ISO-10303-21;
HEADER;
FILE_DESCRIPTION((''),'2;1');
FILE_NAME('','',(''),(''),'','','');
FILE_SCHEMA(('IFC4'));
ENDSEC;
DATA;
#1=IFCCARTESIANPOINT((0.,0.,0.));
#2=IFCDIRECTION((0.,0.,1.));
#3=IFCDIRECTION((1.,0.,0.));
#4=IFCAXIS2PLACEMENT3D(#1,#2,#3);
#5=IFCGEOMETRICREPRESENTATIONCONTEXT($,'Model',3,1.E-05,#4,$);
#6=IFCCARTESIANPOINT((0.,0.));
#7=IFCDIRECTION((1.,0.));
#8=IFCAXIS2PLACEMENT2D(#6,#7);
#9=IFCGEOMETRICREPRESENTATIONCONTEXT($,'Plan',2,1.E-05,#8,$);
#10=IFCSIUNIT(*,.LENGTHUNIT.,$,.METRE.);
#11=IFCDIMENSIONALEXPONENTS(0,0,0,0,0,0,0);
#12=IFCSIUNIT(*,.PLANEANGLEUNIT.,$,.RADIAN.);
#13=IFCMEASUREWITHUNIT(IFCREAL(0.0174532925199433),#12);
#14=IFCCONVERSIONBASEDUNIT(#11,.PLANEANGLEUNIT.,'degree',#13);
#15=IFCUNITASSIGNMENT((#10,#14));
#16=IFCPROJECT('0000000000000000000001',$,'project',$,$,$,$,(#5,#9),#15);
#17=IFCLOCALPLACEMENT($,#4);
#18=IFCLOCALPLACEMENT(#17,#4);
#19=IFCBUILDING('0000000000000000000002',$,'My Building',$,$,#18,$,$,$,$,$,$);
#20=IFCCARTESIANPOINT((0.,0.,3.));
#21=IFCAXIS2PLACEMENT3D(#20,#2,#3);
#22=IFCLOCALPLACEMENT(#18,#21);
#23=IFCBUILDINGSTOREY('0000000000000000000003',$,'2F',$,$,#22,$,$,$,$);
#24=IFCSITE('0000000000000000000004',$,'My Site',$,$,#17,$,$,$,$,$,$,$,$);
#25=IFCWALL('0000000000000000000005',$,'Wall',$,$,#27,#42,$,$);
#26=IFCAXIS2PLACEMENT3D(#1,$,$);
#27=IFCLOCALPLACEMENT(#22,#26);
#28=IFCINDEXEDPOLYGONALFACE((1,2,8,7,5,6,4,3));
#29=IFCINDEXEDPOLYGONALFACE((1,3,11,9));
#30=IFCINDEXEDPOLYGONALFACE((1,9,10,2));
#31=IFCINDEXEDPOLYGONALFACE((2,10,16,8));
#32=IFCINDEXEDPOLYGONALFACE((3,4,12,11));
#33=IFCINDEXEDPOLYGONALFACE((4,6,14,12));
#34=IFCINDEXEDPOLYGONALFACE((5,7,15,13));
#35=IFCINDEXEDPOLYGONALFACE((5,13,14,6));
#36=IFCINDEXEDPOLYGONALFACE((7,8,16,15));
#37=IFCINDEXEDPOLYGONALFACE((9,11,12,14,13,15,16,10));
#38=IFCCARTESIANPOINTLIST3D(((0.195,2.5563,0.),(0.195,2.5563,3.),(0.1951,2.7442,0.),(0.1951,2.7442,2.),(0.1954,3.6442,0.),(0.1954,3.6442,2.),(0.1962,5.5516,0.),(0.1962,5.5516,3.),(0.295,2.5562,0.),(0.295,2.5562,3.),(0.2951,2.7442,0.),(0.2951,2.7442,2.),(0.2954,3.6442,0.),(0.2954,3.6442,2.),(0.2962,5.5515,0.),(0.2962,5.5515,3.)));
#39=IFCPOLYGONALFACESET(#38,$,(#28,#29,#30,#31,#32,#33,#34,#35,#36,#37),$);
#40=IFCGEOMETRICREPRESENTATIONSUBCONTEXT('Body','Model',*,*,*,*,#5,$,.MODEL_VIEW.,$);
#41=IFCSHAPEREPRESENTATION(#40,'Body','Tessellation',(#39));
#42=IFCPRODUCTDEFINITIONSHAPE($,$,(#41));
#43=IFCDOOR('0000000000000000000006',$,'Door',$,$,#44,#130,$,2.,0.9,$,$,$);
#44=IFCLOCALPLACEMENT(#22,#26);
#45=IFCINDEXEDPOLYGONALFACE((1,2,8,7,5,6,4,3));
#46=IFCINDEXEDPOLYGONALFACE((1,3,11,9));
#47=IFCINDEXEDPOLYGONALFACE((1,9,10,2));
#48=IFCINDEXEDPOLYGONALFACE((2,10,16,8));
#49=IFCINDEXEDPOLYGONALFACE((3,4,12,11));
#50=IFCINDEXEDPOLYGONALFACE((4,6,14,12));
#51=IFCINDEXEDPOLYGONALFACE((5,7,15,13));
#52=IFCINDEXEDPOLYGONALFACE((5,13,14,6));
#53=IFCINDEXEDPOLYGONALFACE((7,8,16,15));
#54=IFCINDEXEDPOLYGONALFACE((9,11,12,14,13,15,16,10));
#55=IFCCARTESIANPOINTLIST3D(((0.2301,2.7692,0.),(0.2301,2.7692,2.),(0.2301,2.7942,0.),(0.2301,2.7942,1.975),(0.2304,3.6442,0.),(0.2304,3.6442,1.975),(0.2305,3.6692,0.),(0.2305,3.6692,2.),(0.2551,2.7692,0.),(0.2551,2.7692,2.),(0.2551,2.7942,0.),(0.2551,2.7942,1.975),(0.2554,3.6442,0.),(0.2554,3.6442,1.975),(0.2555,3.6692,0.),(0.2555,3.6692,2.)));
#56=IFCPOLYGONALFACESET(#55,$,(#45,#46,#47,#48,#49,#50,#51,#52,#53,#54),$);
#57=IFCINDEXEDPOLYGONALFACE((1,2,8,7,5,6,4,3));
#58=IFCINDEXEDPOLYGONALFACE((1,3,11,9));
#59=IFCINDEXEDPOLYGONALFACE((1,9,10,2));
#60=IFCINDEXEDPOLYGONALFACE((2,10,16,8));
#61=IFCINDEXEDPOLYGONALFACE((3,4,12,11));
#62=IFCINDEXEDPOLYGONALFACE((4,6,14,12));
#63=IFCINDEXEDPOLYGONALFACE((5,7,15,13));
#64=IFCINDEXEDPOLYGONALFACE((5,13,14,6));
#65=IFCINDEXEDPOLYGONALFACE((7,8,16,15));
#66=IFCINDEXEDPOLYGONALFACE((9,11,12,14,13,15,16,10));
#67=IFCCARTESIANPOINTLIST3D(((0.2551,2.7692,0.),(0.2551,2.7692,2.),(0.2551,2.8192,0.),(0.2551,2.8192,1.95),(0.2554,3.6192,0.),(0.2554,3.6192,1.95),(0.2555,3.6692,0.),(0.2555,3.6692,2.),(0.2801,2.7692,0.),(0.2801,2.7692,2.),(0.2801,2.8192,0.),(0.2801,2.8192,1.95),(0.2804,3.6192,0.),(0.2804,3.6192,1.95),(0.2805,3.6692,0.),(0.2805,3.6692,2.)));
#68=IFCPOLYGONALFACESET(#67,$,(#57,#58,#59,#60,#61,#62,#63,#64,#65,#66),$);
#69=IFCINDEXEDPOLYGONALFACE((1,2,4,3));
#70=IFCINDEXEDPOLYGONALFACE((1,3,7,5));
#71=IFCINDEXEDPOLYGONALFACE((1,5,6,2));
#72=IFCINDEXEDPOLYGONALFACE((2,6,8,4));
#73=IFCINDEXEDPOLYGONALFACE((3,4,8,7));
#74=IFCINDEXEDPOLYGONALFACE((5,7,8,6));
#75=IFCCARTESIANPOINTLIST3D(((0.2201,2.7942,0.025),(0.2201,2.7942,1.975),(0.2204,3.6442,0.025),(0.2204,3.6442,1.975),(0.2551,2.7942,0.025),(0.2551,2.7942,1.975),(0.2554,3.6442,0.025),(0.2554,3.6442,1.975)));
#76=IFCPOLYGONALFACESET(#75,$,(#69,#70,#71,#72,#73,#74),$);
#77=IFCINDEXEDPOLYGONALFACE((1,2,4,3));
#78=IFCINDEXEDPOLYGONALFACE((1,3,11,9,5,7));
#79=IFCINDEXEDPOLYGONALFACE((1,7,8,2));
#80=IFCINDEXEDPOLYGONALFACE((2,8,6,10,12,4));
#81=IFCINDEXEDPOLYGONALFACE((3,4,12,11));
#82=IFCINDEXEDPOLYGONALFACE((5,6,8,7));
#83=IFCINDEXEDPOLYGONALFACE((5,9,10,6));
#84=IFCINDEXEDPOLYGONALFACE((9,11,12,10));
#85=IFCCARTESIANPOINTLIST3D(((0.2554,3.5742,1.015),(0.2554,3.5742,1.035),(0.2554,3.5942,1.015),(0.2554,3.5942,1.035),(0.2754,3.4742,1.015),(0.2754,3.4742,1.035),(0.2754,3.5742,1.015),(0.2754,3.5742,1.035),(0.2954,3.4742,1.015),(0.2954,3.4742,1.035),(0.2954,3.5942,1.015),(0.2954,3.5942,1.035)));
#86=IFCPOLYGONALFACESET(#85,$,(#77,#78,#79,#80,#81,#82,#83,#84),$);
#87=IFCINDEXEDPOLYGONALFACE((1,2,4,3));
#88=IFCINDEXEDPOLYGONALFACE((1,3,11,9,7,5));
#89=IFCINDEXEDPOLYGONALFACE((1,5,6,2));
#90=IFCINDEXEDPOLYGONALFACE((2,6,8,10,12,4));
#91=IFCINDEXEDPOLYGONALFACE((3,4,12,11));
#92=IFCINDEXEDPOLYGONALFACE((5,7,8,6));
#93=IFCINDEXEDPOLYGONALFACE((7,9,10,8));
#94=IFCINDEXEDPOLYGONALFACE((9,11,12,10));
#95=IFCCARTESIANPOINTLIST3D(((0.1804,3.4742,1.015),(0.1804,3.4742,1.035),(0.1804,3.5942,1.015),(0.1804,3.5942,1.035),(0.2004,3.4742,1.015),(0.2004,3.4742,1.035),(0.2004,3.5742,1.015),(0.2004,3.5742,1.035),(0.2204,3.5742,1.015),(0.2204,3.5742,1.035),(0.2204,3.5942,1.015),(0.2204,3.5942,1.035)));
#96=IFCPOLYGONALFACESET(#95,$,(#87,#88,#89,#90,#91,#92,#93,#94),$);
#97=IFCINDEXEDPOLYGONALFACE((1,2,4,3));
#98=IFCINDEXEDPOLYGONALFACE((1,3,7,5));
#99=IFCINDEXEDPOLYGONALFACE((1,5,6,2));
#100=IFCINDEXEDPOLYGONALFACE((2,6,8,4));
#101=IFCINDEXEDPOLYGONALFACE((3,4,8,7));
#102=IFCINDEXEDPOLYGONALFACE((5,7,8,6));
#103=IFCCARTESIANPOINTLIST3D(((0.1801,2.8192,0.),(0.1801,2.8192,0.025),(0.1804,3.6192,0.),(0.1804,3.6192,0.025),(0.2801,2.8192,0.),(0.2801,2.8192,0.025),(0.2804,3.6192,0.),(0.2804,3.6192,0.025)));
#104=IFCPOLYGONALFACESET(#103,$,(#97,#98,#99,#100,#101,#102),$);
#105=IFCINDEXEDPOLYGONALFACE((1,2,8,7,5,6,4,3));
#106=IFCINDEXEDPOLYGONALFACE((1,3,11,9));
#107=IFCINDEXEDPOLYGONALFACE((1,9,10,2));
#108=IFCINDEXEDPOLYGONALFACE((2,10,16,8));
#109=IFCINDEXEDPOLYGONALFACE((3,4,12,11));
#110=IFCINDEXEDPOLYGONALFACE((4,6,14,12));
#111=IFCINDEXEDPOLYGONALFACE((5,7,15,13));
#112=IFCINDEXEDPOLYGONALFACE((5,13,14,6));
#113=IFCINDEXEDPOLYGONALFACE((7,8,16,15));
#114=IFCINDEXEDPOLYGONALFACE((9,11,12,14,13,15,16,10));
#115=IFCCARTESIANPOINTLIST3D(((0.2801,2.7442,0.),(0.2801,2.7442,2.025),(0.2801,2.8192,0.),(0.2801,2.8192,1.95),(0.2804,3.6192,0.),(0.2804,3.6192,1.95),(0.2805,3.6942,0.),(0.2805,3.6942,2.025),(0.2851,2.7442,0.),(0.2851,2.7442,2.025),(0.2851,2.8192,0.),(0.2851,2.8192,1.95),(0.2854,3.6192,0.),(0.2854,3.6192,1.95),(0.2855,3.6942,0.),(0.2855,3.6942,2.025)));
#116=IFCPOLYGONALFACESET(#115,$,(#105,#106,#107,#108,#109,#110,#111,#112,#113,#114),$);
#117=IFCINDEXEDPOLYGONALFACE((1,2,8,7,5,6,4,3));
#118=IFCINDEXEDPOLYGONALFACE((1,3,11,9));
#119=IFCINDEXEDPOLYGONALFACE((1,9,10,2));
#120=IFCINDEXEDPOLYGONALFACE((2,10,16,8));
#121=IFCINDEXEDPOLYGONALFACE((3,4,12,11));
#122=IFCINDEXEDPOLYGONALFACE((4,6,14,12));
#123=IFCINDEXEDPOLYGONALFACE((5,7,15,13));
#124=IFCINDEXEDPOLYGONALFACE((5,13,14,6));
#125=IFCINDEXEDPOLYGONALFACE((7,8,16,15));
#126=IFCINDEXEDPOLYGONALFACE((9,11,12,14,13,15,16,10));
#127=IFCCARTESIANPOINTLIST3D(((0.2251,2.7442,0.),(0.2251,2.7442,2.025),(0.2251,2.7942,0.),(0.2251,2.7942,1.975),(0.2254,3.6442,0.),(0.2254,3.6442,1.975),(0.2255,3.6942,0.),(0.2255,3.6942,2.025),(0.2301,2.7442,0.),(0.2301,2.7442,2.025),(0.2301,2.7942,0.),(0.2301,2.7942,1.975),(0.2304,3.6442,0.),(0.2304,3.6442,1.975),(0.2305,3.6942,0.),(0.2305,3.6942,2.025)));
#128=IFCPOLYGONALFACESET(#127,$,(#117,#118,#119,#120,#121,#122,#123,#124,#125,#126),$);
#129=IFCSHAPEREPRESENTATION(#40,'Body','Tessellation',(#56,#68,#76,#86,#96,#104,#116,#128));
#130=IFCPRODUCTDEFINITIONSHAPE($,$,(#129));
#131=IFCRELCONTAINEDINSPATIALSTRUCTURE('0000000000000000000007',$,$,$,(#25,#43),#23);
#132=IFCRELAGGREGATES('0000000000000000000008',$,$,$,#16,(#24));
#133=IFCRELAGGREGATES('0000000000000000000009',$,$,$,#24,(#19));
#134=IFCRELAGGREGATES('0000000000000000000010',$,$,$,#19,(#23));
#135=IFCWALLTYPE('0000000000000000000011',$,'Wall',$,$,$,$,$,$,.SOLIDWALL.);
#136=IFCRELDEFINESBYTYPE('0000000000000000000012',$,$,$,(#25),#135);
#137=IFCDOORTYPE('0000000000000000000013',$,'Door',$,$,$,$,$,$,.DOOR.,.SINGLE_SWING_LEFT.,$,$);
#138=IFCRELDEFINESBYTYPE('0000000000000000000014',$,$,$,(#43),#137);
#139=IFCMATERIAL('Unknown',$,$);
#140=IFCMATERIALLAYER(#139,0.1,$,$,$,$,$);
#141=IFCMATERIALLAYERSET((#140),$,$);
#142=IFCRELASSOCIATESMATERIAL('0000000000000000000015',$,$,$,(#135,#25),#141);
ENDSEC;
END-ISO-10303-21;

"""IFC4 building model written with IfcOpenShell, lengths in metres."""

from ifc_helpers import new_model, entity, si_unit, converted_unit, frame, origin_with_axes, origin_2d_with_axis, place, context, subcontext, project, spatial, line, indexed_curve, outline, extrude, shape, source, transform, mapped, material, layer, layer_set, layer_usage, type_object, type_shapes, element, fill, save


model = new_model("IFC4")

# Units and contexts
model_context = context("Model", 3, precision=1e-05, world=origin_with_axes())
plan_context = context("Plan", 2, precision=1e-05, world=origin_2d_with_axis())
body_context_1 = subcontext(model_context, "Body", "Model", "MODEL_VIEW")
body_context_2 = subcontext(plan_context, "Body", "Plan", "PLAN_VIEW")
ifc_project = project(units=[si_unit("LENGTHUNIT", "METRE"), converted_unit("PLANEANGLEUNIT", "degree", entity("IfcReal", 0.0174532925199433), si_unit("PLANEANGLEUNIT", "RADIAN"), dimensions=[0, 0, 0, 0, 0, 0, 0])], contexts=[model_context, plan_context])

# Site, building, storey
site_placement = place(None, origin_with_axes())
site = spatial("IfcSite", under=ifc_project, at=site_placement, Name="My Site")
building_placement = place(site_placement, origin_with_axes())
building = spatial("IfcBuilding", under=site, at=building_placement, Name="My Building")
storey_placement = place(building_placement, frame((0.0, 0.0, 3.0), z_axis=(0.0, 0.0, 1.0), x_axis=(1.0, 0.0, 0.0)))
storey = spatial("IfcBuildingStorey", under=building, at=storey_placement, Name="2F")

# Shared definitions
ifc_material = material(Name="Unknown")

# Shared definitions
ifc_layer = layer(ifc_material, 0.1)
ifc_layer_set = layer_set([ifc_layer])
wall_type = type_object("IfcWallType", Name="Wall", PredefinedType="SOLIDWALL", material=ifc_layer_set)

# Wall, opening, door
ifc_layer_usage_1 = layer_usage(ifc_layer_set, "AXIS2", "POSITIVE", 0.0)
wall_1_placement = place(storey_placement, frame((0.1962, 5.5516, 0.0), z_axis=(0.0, 0.0, 1.0), x_axis=(-0.000399, -1.0, 0.0)))
wall_1 = element("IfcWall", 1, at=wall_1_placement, inside=storey, type_object=wall_type, material=ifc_layer_usage_1, Name="Wall", context=body_context_1, shape_type="SweptSolid", body=[
    extrude(outline(indexed_curve([(0.0, 0.0), (0.0, 0.1), (2.9953, 0.1), (2.9953, 0.0)], segments=[line(1, 2, 3, 4, 1)])), origin_with_axes(), (0.0, 0.0, 1.0), 3.0),
])
shared_shape_1 = source(origin_with_axes(), body_context_1, "Body", "SweptSolid", [
    extrude(outline(indexed_curve([(0.0, 0.0), (0.9, 0.0), (0.9, 2.0), (0.0, 2.0)], segments=[line(1, 2, 3, 4, 1)])), frame((0.0, -0.6, 0.0), z_axis=(0.0, -1.0, 0.0), x_axis=(1.0, 0.0, 0.0)), (0.0, 0.0, -1.0), 1.2),
])
opening_1_placement = place(wall_1_placement, frame((1.9074, 0.0, 0.0), z_axis=(0.0, 0.0, 1.0), x_axis=(1.0, 0.0, 0.0)))
opening_1 = element("IfcOpeningElement", 2, at=opening_1_placement, cuts=wall_1, PredefinedType="OPENING", context=body_context_1, shape_type="MappedRepresentation", body=[
    mapped(shared_shape_1, transform((0.0, 0.0, 0.0), x_axis=(1.0, 0.0, 0.0), y_axis=(0.0, 1.0, 0.0), z_axis=(0.0, 0.0, 1.0), scale=1.0)),
])
door_type_1 = type_object("IfcDoorType", Name="Door", OperationType="SINGLE_SWING_LEFT", PredefinedType="DOOR")
shared_shape_2 = source(origin_with_axes(), body_context_1, "Body", "SweptSolid", [
    extrude(outline(indexed_curve([(0.0, 0.0), (0.0, 2.0), (0.9, 2.0), (0.9, 0.0), (0.875, 0.0), (0.875, 1.975), (0.025, 1.975), (0.025, 0.0)], segments=[line(1, 2, 3, 4, 5, 6, 7, 8, 1)])), frame((0.0, 0.025, 0.0), z_axis=(0.0, -1.0, 0.0), x_axis=(1.0, 0.0, 0.0)), (0.0, 0.0, -1.0), 0.025),
    extrude(outline(indexed_curve([(0.0, 0.0), (0.0, 2.0), (0.9, 2.0), (0.9, 0.0), (0.85, 0.0), (0.85, 1.95), (0.05, 1.95), (0.05, 0.0)], segments=[line(1, 2, 3, 4, 5, 6, 7, 8, 1)])), frame((0.0, 0.0, 0.0), z_axis=(0.0, -1.0, 0.0), x_axis=(1.0, 0.0, 0.0)), (0.0, 0.0, -1.0), 0.025),
    extrude(outline(indexed_curve([(0.0, 0.0), (0.85, 0.0), (0.85, 0.035), (0.0, 0.035)], segments=[line(1, 2, 3, 4, 1)])), frame((0.025, 0.025, 0.025), z_axis=(0.0, 0.0, 1.0), x_axis=(1.0, 0.0, 0.0)), (0.0, 0.0, 1.0), 1.95),
    extrude(outline(indexed_curve([(0.0, 0.0), (0.0, -0.04), (-0.12, -0.04), (-0.12, -0.02), (-0.02, -0.02), (-0.02, 0.0)], segments=[line(1, 2, 3, 4, 5, 6, 1)])), frame((0.825, 0.025, 1.015), z_axis=(0.0, 0.0, 1.0), x_axis=(1.0, 0.0, 0.0)), (0.0, 0.0, 1.0), 0.02),
    extrude(outline(indexed_curve([(0.0, 0.0), (0.0, 0.04), (-0.12, 0.04), (-0.12, 0.02), (-0.02, 0.02), (-0.02, 0.0)], segments=[line(1, 2, 3, 4, 5, 6, 1)])), frame((0.825, 0.06, 1.015), z_axis=(0.0, 0.0, 1.0), x_axis=(1.0, 0.0, 0.0)), (0.0, 0.0, 1.0), 0.02),
    extrude(outline(indexed_curve([(0.0, 0.0), (0.8, 0.0), (0.8, 0.1), (0.0, 0.1)], segments=[line(1, 2, 3, 4, 1)])), frame((0.05, 0.0, 0.0), z_axis=(0.0, 0.0, 1.0), x_axis=(1.0, 0.0, 0.0)), (0.0, 0.0, 1.0), 0.025),
    extrude(outline(indexed_curve([(0.0, 0.0), (0.0, 2.025), (0.95, 2.025), (0.95, 0.0), (0.875, 0.0), (0.875, 1.95), (0.075, 1.95), (0.075, 0.0)], segments=[line(1, 2, 3, 4, 5, 6, 7, 8, 1)])), frame((-0.025, -0.005, 0.0), z_axis=(0.0, -1.0, 0.0), x_axis=(1.0, 0.0, 0.0)), (0.0, 0.0, -1.0), 0.005),
    extrude(outline(indexed_curve([(0.0, 0.0), (0.0, 2.025), (0.95, 2.025), (0.95, 0.0), (0.9, 0.0), (0.9, 1.975), (0.05, 1.975), (0.05, 0.0)], segments=[line(1, 2, 3, 4, 5, 6, 7, 8, 1)])), frame((-0.025, 0.05, 0.0), z_axis=(0.0, -1.0, 0.0), x_axis=(1.0, 0.0, 0.0)), (0.0, 0.0, -1.0), 0.005),
])
shared_shape_3 = source(origin_with_axes(), body_context_2, "Body", "Curve2D", [
    entity("IfcIndexedPolyCurve", entity("IfcCartesianPointList2D", [[0.0, 0.0], [0.0, 0.05], [0.025, 0.05], [0.025, 0.025], [0.05, 0.025], [0.05, 0.0]]), [entity("IfcLineIndex", [1, 2, 3, 4, 5, 6, 1])]),
    entity("IfcIndexedPolyCurve", entity("IfcCartesianPointList2D", [[0.9, 0.0], [0.9, 0.05], [0.875, 0.05], [0.875, 0.025], [0.85, 0.025], [0.85, 0.0]]), [entity("IfcLineIndex", [1, 2, 3, 4, 5, 6, 1])]),
    entity("IfcTrimmedCurve", entity("IfcEllipse", entity("IfcAxis2Placement2D", entity("IfcCartesianPoint", [0.06, 0.05]), entity("IfcDirection", [1.0, 0.0])), 0.815, 0.85), [entity("IfcCartesianPoint", [0.875, 0.05])], [entity("IfcCartesianPoint", [0.06, 0.9])], True, "CARTESIAN"),
    entity("IfcIndexedPolyCurve", entity("IfcCartesianPointList2D", [[0.025, 0.05], [0.06, 0.05], [0.06, 0.9], [0.025, 0.9]]), [entity("IfcLineIndex", [1, 2, 3, 4, 1])]),
])
type_shapes(door_type_1, [shared_shape_2, shared_shape_3])
door_1_placement = place(opening_1_placement, frame((0.875, 0.085, 0.0), z_axis=(0.0, 0.0, 1.0), x_axis=(-1.0, 0.0, 0.0)))
door_1 = element("IfcDoor", 3, at=door_1_placement, inside=storey, type_object=door_type_1, Name="Door", OverallHeight=2.0, OverallWidth=0.9, shapes=[
    shape(body_context_1, "Body", "MappedRepresentation", [mapped(shared_shape_2, transform((0.0, 0.0, 0.0), x_axis=(1.0, 0.0, 0.0), y_axis=(0.0, 1.0, 0.0), z_axis=(0.0, 0.0, 1.0), scale=1.0))]),
    shape(body_context_2, "Body", "MappedRepresentation", [mapped(shared_shape_3, transform((0.0, 0.0, 0.0), x_axis=(1.0, 0.0, 0.0), y_axis=(0.0, 1.0, 0.0), z_axis=(0.0, 0.0, 1.0), scale=1.0))]),
])
fill(opening_1, door_1)

save(model, "model.ifc")
